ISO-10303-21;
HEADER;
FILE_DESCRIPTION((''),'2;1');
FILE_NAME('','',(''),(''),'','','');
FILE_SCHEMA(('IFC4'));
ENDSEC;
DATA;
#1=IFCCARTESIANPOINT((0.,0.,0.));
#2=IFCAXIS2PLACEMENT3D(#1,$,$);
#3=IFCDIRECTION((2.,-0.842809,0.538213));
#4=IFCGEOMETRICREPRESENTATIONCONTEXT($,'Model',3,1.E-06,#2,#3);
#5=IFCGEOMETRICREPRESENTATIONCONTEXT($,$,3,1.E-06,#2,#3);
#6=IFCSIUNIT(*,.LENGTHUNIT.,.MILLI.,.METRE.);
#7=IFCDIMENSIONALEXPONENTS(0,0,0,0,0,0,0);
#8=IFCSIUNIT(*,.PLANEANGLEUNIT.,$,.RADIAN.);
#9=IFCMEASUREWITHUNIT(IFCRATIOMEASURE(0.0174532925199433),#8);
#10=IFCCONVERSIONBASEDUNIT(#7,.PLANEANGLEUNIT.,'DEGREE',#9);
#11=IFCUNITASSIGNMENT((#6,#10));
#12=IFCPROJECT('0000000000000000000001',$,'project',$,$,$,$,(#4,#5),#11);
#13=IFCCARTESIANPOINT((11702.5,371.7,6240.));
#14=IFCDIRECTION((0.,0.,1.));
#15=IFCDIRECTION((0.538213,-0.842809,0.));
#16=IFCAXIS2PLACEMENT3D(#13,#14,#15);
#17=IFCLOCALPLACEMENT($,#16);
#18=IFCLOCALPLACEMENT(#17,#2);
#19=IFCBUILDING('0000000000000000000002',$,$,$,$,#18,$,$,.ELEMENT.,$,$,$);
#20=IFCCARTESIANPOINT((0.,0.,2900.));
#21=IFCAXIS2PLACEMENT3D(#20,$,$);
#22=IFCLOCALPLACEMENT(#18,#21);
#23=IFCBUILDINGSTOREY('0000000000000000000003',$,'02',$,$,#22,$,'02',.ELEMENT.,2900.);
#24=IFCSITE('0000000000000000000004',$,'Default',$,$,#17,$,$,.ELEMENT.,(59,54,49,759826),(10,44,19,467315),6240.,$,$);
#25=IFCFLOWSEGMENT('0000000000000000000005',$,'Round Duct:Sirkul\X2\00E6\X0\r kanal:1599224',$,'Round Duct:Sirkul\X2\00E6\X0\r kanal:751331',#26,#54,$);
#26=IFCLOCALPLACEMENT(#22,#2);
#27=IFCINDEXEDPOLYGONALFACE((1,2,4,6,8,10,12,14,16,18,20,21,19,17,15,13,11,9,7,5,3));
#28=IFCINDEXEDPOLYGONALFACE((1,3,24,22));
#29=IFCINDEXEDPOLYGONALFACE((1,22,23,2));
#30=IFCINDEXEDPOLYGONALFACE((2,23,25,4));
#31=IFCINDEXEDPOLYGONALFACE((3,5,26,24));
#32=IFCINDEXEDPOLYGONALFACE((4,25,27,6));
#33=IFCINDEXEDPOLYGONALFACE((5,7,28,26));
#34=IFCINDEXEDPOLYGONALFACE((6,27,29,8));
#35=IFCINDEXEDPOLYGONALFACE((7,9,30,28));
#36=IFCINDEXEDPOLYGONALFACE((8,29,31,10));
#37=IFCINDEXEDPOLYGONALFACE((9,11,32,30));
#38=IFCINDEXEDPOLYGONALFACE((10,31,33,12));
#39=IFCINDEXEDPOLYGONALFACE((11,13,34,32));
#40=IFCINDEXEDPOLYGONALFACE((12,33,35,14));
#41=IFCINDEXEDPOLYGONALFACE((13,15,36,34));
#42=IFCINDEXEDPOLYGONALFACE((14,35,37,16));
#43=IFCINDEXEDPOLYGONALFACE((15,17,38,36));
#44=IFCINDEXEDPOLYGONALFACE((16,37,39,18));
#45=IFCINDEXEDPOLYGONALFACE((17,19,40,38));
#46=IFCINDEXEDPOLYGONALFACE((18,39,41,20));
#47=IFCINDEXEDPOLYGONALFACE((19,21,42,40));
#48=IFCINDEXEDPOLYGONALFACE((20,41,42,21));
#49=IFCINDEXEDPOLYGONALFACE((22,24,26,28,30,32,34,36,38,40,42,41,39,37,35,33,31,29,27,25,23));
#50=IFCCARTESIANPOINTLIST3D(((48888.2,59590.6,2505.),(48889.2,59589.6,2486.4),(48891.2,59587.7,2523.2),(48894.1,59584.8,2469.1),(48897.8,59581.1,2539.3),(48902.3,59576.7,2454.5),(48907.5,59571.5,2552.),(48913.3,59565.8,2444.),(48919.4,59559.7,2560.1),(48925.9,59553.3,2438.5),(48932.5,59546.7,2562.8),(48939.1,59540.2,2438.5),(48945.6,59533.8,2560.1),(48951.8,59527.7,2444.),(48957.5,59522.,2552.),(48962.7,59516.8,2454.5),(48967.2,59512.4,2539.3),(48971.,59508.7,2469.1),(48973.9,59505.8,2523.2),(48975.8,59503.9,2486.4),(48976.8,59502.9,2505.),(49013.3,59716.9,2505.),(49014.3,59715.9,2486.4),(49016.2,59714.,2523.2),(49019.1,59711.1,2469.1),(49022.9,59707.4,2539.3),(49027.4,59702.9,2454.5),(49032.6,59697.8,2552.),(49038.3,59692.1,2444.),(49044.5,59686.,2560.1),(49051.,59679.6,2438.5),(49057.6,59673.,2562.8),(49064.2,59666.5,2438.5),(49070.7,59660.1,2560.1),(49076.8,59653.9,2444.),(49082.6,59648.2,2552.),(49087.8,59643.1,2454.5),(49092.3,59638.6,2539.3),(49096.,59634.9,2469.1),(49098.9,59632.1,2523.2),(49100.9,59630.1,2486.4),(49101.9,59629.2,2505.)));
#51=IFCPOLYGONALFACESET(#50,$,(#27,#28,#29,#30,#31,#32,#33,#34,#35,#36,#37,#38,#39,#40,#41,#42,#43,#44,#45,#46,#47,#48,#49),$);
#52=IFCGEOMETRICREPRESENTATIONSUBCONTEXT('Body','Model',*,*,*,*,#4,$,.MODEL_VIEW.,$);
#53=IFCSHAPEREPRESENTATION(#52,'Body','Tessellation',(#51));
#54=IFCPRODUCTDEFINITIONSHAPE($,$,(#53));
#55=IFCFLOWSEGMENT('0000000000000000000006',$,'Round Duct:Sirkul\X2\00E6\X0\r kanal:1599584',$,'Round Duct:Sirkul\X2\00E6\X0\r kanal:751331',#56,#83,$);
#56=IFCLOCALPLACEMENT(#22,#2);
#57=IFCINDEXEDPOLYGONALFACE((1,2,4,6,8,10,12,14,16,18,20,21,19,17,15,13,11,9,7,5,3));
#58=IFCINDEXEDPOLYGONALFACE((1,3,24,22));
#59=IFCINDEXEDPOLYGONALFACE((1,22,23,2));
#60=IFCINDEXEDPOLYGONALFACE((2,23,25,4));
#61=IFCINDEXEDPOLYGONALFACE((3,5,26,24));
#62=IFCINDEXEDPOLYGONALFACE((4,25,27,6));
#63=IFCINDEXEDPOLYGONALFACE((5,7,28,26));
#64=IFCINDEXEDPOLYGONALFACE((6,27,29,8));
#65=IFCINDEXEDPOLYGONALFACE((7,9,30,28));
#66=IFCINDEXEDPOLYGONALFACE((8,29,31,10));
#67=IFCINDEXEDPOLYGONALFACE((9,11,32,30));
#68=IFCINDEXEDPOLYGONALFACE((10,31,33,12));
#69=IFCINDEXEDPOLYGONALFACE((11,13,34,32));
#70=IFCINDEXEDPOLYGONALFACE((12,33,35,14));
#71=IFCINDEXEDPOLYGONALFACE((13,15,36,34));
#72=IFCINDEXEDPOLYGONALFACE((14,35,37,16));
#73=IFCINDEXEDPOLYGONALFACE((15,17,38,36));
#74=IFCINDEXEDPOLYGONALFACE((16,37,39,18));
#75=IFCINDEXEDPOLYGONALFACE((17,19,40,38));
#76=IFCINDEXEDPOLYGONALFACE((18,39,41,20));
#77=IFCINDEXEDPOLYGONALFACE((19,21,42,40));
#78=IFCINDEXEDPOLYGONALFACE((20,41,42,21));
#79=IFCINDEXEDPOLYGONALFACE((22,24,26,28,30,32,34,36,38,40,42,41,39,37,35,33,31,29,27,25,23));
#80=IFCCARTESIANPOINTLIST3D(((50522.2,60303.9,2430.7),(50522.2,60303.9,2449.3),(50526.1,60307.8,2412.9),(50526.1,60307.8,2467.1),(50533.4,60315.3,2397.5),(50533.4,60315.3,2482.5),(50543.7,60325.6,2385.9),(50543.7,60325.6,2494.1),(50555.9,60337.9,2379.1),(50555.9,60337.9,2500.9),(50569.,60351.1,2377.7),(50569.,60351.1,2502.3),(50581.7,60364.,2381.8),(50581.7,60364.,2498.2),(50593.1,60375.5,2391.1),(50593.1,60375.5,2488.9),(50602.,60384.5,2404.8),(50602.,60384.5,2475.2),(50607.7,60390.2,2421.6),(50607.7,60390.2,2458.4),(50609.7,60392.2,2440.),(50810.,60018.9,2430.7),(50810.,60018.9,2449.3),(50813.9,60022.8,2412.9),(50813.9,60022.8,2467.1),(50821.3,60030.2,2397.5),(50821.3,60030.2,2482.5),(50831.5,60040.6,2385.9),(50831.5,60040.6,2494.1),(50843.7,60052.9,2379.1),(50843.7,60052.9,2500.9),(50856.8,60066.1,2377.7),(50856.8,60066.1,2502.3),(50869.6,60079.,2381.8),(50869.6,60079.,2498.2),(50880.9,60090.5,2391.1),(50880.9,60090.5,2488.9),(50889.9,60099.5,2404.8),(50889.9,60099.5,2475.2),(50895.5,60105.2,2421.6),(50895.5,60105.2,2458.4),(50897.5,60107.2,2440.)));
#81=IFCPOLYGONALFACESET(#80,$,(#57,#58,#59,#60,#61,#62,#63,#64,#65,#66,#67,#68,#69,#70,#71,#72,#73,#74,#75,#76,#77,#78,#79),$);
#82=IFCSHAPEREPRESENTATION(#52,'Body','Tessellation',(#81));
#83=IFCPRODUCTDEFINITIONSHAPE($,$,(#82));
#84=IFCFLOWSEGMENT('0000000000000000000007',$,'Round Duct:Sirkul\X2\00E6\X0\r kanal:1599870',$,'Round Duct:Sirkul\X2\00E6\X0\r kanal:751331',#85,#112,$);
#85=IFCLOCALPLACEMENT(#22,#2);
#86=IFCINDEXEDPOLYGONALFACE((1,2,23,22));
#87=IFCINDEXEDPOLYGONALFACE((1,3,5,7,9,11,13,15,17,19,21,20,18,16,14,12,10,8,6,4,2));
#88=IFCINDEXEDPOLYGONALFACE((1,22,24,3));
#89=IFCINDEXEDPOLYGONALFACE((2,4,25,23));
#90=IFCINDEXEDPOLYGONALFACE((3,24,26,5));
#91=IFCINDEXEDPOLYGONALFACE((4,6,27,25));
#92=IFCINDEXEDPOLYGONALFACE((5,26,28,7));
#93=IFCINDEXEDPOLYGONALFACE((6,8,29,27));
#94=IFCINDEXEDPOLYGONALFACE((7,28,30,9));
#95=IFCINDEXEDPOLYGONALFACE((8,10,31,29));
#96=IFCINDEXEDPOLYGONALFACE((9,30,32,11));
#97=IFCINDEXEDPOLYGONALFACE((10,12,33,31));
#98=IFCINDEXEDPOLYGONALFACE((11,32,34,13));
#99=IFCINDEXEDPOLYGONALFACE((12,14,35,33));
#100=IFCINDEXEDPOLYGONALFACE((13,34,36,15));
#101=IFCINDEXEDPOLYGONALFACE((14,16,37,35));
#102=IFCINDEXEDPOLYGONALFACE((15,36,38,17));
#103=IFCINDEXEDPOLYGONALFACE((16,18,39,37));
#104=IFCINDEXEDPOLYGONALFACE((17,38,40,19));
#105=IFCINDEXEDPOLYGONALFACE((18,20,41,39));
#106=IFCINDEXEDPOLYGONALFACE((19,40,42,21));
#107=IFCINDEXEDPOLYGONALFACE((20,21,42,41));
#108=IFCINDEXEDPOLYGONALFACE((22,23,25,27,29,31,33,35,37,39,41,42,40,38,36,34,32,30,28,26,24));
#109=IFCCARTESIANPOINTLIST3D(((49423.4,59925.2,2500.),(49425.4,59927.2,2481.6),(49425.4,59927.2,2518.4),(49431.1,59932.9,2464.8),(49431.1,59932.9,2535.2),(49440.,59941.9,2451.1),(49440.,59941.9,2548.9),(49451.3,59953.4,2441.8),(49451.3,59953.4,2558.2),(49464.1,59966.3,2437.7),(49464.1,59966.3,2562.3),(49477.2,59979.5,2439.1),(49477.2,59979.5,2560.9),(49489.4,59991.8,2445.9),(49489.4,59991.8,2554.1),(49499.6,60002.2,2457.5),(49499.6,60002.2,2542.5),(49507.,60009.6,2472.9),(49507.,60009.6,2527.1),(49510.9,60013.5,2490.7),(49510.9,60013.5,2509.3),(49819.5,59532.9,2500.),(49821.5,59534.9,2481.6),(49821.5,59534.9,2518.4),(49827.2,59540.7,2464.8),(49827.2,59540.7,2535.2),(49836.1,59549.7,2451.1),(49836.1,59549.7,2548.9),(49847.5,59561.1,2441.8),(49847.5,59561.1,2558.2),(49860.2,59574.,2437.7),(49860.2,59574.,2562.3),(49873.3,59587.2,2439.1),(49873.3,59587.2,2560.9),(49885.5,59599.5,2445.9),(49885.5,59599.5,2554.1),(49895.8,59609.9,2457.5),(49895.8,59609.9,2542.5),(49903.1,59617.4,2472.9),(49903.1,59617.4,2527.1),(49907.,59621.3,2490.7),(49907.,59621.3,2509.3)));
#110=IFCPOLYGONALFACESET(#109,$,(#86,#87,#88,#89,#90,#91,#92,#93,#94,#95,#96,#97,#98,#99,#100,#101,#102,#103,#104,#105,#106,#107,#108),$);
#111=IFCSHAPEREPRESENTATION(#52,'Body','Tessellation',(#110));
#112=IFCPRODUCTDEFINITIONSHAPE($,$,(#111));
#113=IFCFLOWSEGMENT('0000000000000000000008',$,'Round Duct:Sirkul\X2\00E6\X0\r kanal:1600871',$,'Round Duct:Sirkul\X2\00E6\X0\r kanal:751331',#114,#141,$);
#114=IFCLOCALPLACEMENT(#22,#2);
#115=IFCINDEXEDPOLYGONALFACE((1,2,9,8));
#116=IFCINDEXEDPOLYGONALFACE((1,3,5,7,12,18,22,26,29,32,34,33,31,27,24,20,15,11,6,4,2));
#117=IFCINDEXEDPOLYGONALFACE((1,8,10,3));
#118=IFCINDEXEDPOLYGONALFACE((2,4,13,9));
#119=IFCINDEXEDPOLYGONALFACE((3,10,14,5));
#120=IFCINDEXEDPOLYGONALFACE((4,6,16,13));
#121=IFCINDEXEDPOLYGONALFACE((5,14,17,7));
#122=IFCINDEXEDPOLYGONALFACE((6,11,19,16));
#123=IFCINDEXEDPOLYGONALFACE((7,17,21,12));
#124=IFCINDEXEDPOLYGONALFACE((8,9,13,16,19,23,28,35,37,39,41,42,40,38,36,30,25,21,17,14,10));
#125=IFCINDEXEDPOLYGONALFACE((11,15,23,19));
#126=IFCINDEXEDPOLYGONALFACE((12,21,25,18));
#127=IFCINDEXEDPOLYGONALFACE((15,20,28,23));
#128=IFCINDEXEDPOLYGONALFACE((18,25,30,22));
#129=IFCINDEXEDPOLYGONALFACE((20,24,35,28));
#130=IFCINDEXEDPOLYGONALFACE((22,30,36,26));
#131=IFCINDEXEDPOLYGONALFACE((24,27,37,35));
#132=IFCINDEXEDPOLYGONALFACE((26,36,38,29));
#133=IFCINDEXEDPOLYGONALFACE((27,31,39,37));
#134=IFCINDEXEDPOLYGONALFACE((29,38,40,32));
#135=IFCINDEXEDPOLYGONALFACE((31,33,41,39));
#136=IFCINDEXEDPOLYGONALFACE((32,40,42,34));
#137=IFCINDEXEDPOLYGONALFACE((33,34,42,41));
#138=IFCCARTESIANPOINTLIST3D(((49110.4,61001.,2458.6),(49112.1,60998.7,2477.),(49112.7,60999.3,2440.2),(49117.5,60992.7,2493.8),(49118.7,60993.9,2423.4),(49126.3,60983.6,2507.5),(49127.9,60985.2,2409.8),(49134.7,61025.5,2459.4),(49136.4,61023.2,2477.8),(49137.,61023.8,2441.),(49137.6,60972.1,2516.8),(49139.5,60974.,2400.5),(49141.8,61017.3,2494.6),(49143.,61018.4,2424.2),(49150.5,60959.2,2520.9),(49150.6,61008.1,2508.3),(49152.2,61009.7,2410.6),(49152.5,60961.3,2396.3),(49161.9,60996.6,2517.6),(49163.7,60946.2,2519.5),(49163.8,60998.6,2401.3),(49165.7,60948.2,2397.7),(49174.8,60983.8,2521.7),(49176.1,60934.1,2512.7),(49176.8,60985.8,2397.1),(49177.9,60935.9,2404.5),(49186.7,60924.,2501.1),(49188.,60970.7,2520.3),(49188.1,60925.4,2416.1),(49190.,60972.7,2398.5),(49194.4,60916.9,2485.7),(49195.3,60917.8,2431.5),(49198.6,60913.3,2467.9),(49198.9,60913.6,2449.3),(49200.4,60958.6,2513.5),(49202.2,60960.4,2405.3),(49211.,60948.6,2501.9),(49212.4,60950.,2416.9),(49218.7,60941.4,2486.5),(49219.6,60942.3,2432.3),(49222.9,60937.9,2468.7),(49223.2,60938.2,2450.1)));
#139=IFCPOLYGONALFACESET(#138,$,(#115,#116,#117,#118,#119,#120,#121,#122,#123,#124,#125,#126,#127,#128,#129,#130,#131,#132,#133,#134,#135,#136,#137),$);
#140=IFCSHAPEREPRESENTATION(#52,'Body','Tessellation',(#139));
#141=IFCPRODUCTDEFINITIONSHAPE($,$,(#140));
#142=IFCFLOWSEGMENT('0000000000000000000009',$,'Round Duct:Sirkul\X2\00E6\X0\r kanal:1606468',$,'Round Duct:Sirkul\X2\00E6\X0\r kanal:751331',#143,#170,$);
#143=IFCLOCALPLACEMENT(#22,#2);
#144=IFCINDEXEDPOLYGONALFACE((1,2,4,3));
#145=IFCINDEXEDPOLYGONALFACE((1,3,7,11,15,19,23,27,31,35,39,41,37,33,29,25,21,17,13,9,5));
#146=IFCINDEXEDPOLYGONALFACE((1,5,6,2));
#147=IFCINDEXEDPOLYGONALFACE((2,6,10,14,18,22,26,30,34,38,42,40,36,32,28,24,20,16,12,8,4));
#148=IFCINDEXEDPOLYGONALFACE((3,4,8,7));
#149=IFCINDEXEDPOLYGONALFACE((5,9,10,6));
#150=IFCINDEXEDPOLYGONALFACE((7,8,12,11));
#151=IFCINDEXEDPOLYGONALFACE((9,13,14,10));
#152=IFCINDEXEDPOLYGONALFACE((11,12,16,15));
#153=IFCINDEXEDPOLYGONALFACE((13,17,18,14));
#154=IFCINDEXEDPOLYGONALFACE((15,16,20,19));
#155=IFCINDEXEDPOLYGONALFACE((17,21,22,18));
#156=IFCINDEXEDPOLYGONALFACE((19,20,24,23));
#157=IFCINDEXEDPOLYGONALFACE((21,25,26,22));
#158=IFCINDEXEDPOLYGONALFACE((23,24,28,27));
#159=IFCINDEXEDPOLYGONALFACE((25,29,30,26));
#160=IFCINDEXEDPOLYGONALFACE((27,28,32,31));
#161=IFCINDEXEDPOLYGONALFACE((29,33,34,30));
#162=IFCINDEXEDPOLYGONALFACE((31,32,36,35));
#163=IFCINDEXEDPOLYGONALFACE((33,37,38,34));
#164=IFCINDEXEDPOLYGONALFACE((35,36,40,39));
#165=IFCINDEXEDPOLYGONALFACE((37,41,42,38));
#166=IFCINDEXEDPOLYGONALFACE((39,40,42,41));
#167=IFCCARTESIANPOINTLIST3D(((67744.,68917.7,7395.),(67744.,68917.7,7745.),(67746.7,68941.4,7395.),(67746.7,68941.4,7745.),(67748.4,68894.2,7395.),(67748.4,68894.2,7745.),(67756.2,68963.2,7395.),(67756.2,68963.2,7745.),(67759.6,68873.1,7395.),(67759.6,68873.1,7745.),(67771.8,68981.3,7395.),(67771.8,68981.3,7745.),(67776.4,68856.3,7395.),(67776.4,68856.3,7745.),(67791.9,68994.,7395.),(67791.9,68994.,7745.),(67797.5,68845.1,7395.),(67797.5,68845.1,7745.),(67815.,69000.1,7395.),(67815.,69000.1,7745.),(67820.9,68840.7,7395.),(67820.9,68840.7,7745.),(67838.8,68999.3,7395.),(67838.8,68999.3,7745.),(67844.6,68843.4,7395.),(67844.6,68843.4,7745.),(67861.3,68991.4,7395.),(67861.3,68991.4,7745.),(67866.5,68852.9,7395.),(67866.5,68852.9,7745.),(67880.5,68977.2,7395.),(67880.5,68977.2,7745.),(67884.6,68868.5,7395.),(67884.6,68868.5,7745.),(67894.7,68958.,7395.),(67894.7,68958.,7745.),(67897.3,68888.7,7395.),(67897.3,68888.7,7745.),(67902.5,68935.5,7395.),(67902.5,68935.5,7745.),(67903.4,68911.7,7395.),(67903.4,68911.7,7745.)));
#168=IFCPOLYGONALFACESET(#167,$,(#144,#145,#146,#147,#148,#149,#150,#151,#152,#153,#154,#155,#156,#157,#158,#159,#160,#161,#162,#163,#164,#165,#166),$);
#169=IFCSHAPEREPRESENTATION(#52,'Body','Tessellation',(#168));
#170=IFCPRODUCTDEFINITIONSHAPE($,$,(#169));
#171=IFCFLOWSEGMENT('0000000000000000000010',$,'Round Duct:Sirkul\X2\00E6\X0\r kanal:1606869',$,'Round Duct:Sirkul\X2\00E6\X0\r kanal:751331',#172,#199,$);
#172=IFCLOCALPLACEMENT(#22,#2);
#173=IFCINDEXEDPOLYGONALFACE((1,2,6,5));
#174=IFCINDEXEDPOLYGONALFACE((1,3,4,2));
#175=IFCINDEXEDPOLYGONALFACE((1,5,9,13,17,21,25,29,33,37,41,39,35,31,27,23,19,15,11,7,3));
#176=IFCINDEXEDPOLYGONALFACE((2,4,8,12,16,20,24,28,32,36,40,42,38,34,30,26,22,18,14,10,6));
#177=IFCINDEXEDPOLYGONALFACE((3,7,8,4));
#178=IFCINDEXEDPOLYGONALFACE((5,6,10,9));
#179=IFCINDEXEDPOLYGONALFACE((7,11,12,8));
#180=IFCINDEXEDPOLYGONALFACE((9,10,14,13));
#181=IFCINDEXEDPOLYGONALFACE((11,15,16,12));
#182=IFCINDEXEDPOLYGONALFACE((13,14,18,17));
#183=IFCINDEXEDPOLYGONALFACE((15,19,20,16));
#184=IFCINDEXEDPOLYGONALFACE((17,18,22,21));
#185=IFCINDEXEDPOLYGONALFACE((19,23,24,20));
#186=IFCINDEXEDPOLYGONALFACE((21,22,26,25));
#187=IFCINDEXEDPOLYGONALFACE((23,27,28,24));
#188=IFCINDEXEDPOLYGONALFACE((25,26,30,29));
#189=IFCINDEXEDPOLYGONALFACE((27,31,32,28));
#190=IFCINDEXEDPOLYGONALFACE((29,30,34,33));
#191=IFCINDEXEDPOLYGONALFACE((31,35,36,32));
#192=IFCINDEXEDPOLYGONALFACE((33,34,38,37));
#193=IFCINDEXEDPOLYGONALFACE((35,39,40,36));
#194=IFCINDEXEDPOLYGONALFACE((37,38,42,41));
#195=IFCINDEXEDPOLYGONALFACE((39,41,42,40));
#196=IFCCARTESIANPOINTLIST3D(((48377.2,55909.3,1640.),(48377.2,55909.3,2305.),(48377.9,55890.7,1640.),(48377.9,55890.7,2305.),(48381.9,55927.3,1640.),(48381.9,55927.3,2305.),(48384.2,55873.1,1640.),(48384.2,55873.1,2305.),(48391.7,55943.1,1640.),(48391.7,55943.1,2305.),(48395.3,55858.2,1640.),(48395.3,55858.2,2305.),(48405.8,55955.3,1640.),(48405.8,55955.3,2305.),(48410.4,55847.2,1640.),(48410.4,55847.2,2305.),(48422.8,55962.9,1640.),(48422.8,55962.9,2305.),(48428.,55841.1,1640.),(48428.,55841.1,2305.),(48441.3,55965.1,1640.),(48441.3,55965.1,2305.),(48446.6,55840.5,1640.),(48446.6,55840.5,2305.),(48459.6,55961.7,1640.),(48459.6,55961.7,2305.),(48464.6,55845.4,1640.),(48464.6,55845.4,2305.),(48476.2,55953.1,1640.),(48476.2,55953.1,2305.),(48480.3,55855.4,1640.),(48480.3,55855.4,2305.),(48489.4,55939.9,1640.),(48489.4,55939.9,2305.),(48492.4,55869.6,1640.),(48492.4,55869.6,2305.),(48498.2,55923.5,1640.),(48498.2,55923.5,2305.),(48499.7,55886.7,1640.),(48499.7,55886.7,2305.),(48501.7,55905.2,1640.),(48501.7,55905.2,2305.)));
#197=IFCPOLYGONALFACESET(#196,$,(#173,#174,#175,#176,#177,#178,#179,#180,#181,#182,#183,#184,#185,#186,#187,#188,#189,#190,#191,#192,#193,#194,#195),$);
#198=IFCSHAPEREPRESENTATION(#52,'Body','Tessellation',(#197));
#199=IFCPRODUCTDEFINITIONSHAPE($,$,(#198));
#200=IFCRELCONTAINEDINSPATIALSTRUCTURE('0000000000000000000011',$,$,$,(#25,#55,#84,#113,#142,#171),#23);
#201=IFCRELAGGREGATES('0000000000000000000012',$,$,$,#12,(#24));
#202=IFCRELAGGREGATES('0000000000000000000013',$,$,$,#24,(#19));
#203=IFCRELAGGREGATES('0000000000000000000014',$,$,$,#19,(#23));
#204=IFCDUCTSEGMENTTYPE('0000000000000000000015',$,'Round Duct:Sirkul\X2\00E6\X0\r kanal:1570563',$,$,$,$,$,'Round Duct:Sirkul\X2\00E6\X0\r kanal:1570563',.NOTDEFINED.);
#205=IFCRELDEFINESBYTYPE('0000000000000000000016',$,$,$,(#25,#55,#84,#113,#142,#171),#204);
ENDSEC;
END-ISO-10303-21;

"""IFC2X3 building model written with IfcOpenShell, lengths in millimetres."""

from ifc_helpers import new_model, entity, si_unit, converted_unit, direction, frame, frame_2d, origin, origin_2d_with_axis, place, context, subcontext, project, spatial, circle, extrude, type_object, element, save


model = new_model("IFC2X3")

# Units and contexts
model_context = context("Model", 3, precision=1e-06, world=origin(), true_north=direction((2.0, -0.842809, 0.538213)))
context_of_model = context(None, 3, precision=1e-06, world=origin(), true_north=direction((2.0, -0.842809, 0.538213)))
body_context = subcontext(model_context, "Body", "Model", "MODEL_VIEW")
ifc_project = project(units=[si_unit("LENGTHUNIT", "METRE", prefix="MILLI"), converted_unit("PLANEANGLEUNIT", "DEGREE", entity("IfcRatioMeasure", 0.0174532925199433), si_unit("PLANEANGLEUNIT", "RADIAN"), dimensions=[0, 0, 0, 0, 0, 0, 0])], contexts=[model_context, context_of_model])

# Site, building, storey
site_placement = place(None, frame((11702.5, 371.7, 6240.0), z_axis=(0.0, 0.0, 1.0), x_axis=(0.538213, -0.842809, 0.0)))
site = spatial("IfcSite", under=ifc_project, at=site_placement, Name="Default", CompositionType="ELEMENT", RefLatitude=(59, 54, 49, 759826), RefLongitude=(10, 44, 19, 467315), RefElevation=6240.0)
building_placement = place(site_placement, origin())
building = spatial("IfcBuilding", under=site, at=building_placement, CompositionType="ELEMENT")
storey_placement = place(building_placement, frame((0.0, 0.0, 2900.0)))
storey = spatial("IfcBuildingStorey", under=building, at=storey_placement, Name="02", LongName="02", CompositionType="ELEMENT", Elevation=2900.0)

# Flow segments
duct_segment_type = type_object("IfcDuctSegmentType", Name="Round Duct:Sirkulær kanal:1570563", ElementType="Round Duct:Sirkulær kanal:1570563", PredefinedType="NOTDEFINED")
flow_segment_1_placement = place(storey_placement, origin())
element("IfcFlowSegment", 1, at=flow_segment_1_placement, inside=storey, type_object=duct_segment_type, Name="Round Duct:Sirkulær kanal:1599224", ObjectType="Round Duct:Sirkulær kanal:751331", context=body_context, shape_type="SweptSolid", body=[
    extrude(circle(Radius=62.5, at=frame_2d((0.0, 0.0), x_axis=(1.0, 0.0))), frame((48932.5, 59546.7, 2500.3), z_axis=(0.703641, 0.710556, 0.0), x_axis=(0.0, 0.0, 1.0)), (0.0, 0.0, 1.0), 177.7),
])
flow_segment_2_placement = place(storey_placement, origin())
element("IfcFlowSegment", 2, at=flow_segment_2_placement, inside=storey, type_object=duct_segment_type, Name="Round Duct:Sirkulær kanal:1599584", ObjectType="Round Duct:Sirkulær kanal:751331", context=body_context, shape_type="SweptSolid", body=[
    extrude(circle(Radius=62.5, at=origin_2d_with_axis()), frame((50853.5, 60062.8, 2440.0), z_axis=(-0.710554, 0.703643, 0.0), x_axis=(0.703643, 0.710554, 0.0)), (0.0, 0.0, 1.0), 405.1),
])
flow_segment_3_placement = place(storey_placement, origin())
element("IfcFlowSegment", 3, at=flow_segment_3_placement, inside=storey, type_object=duct_segment_type, Name="Round Duct:Sirkulær kanal:1599870", ObjectType="Round Duct:Sirkulær kanal:751331", context=body_context, shape_type="SweptSolid", body=[
    extrude(circle(Radius=62.5, at=origin_2d_with_axis()), frame((49863.5, 59577.3, 2500.0), z_axis=(-0.710554, 0.703643, 0.0), x_axis=(-0.703643, -0.710554, 0.0)), (0.0, 0.0, 1.0), 557.5),
])
flow_segment_4_placement = place(storey_placement, origin())
element("IfcFlowSegment", 4, at=flow_segment_4_placement, inside=storey, type_object=duct_segment_type, Name="Round Duct:Sirkulær kanal:1600871", ObjectType="Round Duct:Sirkulær kanal:751331", context=body_context, shape_type="SweptSolid", body=[
    extrude(circle(Radius=62.5, at=origin_2d_with_axis()), frame((49154.8, 60957.0, 2458.6), z_axis=(0.703451, 0.71036, 0.023355), x_axis=(-0.710554, 0.703643, 0.0)), (0.0, 0.0, 1.0), 34.6),
])
flow_segment_5_placement = place(storey_placement, origin())
element("IfcFlowSegment", 5, at=flow_segment_5_placement, inside=storey, type_object=duct_segment_type, Name="Round Duct:Sirkulær kanal:1606468", ObjectType="Round Duct:Sirkulær kanal:751331", context=body_context, shape_type="SweptSolid", body=[
    extrude(circle(Radius=80.0, at=origin_2d_with_axis()), frame((67823.9, 68920.7, 7395.0), z_axis=(0.0, 0.0, 1.0), x_axis=(0.707107, 0.707107, 0.0)), (0.0, 0.0, 1.0), 350.0),
])
flow_segment_6_placement = place(storey_placement, origin())
element("IfcFlowSegment", 6, at=flow_segment_6_placement, inside=storey, type_object=duct_segment_type, Name="Round Duct:Sirkulær kanal:1606869", ObjectType="Round Duct:Sirkulær kanal:751331", context=body_context, shape_type="SweptSolid", body=[
    extrude(circle(Radius=62.5, at=origin_2d_with_axis()), frame((48439.3, 55902.6, 1640.0), z_axis=(0.0, 0.0, 1.0), x_axis=(-0.703625, -0.710572, 0.0)), (0.0, 0.0, 1.0), 665.0),
])

save(model, "model.ifc")
